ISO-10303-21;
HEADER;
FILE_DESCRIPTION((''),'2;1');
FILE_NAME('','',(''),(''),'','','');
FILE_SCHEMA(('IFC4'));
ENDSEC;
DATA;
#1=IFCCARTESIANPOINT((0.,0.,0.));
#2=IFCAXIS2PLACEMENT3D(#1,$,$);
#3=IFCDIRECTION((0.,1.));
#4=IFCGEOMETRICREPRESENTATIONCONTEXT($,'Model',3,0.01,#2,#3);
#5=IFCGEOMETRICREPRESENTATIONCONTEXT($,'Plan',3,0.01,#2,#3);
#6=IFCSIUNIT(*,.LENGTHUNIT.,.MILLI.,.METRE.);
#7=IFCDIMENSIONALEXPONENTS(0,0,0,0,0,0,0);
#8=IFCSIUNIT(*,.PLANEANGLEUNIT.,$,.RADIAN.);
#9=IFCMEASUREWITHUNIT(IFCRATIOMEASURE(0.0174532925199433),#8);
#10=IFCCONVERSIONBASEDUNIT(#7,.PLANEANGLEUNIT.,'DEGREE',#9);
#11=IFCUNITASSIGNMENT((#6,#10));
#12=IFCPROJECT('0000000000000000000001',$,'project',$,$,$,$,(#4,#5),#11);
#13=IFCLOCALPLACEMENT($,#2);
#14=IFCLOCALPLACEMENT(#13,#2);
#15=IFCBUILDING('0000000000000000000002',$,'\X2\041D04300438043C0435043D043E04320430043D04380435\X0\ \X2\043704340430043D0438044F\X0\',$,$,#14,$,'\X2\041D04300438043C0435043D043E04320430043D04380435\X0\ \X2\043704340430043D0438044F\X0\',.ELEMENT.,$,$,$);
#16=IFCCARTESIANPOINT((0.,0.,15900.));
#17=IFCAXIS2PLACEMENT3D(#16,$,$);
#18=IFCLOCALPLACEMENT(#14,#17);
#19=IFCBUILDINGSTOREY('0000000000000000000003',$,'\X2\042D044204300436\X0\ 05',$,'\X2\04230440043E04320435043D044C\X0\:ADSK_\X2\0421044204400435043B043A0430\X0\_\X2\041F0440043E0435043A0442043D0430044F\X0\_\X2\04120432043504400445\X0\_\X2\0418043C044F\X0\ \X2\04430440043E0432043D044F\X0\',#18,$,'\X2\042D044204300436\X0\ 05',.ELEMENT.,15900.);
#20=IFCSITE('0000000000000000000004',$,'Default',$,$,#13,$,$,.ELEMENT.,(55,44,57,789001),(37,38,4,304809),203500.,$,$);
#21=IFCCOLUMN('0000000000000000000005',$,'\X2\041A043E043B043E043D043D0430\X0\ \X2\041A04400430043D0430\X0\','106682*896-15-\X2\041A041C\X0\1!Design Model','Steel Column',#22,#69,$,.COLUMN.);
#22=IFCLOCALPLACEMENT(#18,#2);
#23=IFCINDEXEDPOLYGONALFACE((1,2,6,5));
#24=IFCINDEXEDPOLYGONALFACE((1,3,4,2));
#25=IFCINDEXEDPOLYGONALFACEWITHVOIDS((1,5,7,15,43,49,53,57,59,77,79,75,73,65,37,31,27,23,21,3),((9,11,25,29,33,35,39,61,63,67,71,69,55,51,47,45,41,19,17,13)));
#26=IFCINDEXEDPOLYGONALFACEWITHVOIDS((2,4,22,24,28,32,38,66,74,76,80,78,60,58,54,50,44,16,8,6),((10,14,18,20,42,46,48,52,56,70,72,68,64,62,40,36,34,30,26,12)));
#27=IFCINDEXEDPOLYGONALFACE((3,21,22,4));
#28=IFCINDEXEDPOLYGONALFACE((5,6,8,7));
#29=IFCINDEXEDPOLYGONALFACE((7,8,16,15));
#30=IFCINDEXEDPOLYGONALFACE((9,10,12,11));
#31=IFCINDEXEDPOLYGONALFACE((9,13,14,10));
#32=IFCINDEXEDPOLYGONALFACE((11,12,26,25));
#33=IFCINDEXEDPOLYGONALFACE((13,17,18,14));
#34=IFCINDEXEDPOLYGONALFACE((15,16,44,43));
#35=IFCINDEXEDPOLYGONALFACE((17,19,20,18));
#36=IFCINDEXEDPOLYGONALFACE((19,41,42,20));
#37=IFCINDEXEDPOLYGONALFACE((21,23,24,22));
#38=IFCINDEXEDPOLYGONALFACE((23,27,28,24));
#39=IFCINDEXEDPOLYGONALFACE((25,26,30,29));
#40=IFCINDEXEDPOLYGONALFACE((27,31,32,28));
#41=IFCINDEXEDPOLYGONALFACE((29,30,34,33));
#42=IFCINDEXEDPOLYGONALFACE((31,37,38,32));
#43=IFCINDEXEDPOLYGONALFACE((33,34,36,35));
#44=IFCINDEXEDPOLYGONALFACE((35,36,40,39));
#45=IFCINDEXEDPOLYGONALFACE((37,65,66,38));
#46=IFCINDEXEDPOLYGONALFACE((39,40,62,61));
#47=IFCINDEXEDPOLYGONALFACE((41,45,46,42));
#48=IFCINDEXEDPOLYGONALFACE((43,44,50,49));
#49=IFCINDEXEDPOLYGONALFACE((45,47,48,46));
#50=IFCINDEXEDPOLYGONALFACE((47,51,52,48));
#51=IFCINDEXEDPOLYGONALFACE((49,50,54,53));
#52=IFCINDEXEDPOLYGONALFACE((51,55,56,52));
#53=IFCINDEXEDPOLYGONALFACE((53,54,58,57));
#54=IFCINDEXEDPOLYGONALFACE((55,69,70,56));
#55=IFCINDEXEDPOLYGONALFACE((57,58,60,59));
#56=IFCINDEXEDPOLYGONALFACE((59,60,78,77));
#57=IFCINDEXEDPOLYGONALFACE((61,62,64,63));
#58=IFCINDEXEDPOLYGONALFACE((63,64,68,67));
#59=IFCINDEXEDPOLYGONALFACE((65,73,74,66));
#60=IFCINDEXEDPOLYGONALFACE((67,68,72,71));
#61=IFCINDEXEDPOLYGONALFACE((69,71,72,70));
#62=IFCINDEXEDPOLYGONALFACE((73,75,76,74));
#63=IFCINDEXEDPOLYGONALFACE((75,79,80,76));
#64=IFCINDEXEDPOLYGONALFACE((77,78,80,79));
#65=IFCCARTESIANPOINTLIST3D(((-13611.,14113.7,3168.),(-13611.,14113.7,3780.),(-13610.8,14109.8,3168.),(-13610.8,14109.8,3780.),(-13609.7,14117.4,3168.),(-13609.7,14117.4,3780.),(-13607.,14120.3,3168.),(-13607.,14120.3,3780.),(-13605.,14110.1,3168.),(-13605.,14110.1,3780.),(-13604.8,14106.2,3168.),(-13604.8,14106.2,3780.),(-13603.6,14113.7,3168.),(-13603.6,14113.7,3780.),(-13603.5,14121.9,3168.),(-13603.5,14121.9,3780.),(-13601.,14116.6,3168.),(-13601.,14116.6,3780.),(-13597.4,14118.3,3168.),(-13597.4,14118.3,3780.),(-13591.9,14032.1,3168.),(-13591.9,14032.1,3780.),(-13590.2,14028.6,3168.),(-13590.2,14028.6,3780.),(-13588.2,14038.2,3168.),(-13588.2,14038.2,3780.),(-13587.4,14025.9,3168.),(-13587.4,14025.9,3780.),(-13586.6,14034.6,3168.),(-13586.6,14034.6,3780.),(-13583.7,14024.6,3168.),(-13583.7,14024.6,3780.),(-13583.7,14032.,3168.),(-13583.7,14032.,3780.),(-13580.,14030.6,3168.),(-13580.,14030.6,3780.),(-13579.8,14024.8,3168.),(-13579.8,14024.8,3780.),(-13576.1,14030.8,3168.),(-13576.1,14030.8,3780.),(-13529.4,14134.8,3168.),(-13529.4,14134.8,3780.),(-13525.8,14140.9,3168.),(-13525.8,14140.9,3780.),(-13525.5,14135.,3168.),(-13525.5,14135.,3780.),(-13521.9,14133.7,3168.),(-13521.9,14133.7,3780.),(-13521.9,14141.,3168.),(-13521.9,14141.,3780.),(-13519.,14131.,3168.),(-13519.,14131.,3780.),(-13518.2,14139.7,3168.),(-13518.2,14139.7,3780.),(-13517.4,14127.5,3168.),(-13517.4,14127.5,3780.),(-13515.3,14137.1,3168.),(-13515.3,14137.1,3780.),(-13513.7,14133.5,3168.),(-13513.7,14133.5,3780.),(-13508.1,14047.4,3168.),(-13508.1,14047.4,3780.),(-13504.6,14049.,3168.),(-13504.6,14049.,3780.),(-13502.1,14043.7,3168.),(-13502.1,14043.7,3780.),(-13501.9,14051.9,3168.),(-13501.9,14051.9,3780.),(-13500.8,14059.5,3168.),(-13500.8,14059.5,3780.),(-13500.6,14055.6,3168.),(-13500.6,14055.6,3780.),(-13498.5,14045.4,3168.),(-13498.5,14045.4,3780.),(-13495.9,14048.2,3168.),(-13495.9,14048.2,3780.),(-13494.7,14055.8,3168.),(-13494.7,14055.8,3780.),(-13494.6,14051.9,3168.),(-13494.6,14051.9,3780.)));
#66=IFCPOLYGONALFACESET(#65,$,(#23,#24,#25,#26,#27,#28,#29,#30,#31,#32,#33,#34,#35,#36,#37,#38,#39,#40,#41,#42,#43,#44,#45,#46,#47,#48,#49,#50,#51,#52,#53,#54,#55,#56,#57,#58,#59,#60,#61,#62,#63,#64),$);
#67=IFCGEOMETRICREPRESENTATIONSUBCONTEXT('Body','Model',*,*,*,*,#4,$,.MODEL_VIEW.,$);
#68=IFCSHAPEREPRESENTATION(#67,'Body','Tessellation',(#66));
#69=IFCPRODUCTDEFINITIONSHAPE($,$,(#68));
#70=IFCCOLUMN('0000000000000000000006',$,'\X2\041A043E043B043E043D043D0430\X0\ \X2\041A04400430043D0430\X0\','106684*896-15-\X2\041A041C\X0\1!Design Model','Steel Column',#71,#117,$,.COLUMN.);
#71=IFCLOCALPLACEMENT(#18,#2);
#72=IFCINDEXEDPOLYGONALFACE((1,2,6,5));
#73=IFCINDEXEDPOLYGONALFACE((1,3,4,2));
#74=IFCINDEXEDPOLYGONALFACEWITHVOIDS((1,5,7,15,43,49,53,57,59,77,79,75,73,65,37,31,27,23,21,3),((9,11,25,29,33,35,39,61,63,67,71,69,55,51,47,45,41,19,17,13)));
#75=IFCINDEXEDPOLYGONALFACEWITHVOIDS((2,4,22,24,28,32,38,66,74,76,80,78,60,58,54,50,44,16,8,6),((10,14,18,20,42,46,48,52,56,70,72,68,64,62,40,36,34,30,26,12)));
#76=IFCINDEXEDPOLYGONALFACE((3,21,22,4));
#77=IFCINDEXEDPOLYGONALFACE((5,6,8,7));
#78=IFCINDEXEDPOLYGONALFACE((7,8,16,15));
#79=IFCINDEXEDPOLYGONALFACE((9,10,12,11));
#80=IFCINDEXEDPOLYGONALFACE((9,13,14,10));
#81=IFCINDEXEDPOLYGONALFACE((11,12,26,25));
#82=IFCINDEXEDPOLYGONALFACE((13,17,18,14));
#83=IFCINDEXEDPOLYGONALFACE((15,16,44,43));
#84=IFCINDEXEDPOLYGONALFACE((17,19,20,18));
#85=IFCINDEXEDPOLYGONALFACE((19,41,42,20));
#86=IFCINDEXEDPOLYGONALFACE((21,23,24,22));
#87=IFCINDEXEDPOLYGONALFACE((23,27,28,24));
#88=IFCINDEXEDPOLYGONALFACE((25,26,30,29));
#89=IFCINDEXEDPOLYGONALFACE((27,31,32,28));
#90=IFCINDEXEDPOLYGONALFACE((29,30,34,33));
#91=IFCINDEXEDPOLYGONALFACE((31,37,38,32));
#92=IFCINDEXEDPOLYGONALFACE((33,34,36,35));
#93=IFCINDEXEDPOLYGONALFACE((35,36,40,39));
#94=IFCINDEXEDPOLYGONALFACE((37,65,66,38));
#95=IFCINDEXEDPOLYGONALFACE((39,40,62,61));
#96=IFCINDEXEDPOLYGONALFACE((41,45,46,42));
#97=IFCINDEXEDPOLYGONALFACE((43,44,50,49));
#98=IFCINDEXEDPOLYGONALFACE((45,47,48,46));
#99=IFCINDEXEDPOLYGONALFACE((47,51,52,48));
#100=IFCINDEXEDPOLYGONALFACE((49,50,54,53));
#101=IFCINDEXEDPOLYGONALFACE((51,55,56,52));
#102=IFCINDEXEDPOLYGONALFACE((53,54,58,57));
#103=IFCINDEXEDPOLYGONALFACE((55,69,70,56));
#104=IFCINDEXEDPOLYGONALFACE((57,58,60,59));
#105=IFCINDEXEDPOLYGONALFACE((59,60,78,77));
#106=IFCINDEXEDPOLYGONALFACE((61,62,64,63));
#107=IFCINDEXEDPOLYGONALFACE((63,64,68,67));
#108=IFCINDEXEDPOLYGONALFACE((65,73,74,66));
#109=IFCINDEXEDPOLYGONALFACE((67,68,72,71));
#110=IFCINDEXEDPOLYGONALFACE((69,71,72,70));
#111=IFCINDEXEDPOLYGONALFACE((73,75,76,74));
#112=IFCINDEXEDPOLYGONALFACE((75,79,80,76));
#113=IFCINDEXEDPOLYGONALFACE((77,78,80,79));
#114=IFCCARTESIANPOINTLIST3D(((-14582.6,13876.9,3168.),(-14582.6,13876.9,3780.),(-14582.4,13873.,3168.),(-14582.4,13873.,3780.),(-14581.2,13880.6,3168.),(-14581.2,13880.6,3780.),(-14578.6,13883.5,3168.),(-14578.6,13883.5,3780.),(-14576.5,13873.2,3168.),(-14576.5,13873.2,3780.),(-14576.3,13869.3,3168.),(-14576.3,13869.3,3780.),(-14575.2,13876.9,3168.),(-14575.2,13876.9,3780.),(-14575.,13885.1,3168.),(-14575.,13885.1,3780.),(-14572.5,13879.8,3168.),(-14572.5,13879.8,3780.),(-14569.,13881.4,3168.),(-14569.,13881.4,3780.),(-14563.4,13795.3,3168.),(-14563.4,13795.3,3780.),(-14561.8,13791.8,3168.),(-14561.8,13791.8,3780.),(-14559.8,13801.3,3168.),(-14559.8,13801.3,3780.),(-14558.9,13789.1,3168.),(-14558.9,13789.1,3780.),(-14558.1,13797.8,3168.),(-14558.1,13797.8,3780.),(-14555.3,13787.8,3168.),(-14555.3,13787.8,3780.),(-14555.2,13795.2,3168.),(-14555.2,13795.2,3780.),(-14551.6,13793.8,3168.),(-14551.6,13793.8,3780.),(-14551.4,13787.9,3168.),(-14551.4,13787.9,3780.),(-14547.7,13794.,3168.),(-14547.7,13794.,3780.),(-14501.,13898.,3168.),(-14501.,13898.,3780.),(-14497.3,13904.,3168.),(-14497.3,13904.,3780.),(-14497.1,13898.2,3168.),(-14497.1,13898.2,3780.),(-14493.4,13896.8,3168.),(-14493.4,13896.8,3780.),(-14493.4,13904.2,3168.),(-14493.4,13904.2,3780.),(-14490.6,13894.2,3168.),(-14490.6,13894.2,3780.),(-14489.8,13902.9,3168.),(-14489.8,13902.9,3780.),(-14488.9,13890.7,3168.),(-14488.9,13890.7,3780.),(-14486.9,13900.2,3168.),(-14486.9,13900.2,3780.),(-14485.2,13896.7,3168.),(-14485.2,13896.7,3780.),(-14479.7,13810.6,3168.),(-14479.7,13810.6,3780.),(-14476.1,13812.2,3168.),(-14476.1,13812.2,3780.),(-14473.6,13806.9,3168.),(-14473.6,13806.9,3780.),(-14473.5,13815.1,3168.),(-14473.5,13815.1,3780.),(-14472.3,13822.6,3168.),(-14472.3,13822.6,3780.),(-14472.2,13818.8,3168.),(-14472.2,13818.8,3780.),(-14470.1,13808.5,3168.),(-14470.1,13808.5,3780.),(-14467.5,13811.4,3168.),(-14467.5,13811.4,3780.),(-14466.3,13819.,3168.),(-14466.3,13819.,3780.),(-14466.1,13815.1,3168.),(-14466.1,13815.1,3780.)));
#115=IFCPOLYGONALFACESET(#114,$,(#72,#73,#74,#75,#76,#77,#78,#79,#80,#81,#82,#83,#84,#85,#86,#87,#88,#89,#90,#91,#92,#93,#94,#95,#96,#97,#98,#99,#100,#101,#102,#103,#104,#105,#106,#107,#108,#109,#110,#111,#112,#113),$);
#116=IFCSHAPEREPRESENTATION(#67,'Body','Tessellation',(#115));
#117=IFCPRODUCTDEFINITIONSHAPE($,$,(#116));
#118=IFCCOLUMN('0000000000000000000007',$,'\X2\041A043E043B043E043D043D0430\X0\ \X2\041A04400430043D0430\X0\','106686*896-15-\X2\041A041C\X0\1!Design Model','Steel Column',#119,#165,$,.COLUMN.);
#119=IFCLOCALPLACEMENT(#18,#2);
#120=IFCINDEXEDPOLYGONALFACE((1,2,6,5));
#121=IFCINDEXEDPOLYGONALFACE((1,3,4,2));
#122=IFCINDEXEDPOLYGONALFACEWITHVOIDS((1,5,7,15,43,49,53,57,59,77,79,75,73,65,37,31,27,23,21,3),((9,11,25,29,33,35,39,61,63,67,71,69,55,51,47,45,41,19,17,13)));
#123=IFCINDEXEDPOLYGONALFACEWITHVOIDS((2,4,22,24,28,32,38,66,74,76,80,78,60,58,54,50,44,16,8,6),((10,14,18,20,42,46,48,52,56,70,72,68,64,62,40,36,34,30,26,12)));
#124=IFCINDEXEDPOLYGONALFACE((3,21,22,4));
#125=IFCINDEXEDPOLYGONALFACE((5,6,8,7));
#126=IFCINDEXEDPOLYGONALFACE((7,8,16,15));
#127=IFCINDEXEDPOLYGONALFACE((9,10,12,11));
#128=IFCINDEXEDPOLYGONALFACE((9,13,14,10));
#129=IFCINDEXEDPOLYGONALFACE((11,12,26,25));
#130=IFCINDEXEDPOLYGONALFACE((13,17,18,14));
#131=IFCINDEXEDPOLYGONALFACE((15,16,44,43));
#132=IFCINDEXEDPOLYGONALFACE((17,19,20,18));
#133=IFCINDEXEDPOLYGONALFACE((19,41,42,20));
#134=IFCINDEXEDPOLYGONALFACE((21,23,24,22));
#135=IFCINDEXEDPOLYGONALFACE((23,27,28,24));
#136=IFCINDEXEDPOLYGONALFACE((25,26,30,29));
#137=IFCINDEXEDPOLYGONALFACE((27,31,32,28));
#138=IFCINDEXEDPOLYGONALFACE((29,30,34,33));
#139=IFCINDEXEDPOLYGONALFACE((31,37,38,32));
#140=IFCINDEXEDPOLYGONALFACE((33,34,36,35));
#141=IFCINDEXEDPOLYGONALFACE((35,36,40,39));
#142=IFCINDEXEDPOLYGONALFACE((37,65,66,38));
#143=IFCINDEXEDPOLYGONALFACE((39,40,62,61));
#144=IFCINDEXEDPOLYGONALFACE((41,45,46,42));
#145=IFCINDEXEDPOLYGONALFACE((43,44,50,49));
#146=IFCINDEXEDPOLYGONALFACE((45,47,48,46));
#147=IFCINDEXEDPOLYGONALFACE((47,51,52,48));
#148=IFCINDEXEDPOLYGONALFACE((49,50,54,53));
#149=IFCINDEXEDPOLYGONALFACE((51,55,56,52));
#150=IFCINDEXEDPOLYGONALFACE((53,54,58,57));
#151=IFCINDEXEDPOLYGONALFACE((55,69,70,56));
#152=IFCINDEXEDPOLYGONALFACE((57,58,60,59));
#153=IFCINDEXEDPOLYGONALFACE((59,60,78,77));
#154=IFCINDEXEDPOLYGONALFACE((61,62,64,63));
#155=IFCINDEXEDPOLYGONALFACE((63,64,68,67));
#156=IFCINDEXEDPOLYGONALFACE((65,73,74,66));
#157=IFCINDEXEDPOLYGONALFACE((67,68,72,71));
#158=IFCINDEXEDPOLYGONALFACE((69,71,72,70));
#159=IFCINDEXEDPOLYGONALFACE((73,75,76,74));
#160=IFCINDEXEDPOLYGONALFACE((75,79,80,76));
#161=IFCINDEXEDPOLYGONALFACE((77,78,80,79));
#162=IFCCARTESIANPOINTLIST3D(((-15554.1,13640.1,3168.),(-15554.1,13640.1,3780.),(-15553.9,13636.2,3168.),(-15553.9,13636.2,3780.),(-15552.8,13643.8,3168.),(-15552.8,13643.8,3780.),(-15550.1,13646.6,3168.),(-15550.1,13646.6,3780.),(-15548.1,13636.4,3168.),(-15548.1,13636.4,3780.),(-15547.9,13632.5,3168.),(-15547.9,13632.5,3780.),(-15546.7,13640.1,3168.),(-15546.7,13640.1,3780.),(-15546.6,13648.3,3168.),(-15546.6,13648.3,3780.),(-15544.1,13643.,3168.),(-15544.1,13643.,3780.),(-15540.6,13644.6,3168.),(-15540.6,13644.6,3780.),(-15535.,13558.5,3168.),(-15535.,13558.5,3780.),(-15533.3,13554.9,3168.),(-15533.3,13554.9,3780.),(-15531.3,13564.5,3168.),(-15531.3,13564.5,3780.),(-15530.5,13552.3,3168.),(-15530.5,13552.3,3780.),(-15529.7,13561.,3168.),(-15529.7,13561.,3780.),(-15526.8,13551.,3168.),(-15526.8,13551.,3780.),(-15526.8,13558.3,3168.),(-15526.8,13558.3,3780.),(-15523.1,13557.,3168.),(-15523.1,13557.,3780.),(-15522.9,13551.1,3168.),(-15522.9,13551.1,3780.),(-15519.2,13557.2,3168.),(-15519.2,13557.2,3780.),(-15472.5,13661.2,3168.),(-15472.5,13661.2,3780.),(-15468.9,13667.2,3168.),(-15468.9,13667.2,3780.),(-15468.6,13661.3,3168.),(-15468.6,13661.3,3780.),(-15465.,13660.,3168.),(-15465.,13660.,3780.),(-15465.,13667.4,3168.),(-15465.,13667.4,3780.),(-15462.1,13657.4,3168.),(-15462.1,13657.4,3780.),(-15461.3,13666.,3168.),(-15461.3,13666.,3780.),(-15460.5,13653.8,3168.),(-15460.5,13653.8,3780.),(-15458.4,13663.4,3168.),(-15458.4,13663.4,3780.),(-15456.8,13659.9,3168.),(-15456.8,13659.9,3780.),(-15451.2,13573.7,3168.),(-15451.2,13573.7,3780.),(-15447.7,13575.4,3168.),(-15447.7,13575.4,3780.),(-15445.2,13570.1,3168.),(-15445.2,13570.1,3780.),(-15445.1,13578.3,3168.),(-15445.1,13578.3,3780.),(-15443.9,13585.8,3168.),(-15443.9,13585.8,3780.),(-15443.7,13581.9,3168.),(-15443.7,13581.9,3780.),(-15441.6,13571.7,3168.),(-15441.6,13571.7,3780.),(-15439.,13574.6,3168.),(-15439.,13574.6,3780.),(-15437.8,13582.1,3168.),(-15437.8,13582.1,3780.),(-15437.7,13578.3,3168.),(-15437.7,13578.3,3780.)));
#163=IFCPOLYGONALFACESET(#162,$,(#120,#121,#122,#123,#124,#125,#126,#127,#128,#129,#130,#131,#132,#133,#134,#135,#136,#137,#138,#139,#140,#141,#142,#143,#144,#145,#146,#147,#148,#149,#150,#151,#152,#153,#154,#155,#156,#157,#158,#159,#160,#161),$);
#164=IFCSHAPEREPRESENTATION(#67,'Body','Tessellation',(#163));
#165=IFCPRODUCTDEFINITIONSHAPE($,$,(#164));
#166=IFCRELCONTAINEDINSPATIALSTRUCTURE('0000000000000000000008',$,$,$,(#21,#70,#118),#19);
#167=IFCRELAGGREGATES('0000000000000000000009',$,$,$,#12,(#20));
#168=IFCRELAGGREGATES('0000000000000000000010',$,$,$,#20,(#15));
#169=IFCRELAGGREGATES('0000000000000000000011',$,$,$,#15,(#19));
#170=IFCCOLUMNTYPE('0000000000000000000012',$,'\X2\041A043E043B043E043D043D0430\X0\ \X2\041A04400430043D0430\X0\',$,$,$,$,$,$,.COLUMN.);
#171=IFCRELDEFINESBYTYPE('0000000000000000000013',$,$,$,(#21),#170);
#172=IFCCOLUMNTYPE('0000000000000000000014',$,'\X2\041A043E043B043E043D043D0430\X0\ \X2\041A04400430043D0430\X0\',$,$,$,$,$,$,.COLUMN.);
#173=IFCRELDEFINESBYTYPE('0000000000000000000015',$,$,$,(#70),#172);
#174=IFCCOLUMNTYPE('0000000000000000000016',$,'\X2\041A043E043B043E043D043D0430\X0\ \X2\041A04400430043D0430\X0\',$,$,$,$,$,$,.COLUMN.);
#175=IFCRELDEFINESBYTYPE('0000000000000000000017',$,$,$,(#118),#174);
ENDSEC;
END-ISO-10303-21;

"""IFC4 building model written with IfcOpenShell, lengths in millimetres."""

from ifc_helpers import new_model, entity, si_unit, converted_unit, direction, frame, origin, place, context, subcontext, project, spatial, indexed_curve, outline, extrude, type_object, element, save


model = new_model("IFC4")

# Units and contexts
model_context = context("Model", 3, precision=0.01, world=origin(), true_north=direction((0.0, 1.0)))
plan_context = context("Plan", 3, precision=0.01, world=origin(), true_north=direction((0.0, 1.0)))
body_context = subcontext(model_context, "Body", "Model", "MODEL_VIEW")
ifc_project = project(units=[si_unit("LENGTHUNIT", "METRE", prefix="MILLI"), converted_unit("PLANEANGLEUNIT", "DEGREE", entity("IfcRatioMeasure", 0.0174532925199433), si_unit("PLANEANGLEUNIT", "RADIAN"), dimensions=[0, 0, 0, 0, 0, 0, 0])], contexts=[model_context, plan_context])

# Site, building, storey
site_placement = place(None, origin())
site = spatial("IfcSite", under=ifc_project, at=site_placement, Name="Default", CompositionType="ELEMENT", RefLatitude=(55, 44, 57, 789001), RefLongitude=(37, 38, 4, 304809), RefElevation=203500.0)
building_placement = place(site_placement, origin())
building = spatial("IfcBuilding", under=site, at=building_placement, Name="Наименование здания", LongName="Наименование здания", CompositionType="ELEMENT")
storey_placement = place(building_placement, frame((0.0, 0.0, 15900.0)))
storey = spatial("IfcBuildingStorey", under=building, at=storey_placement, Name="Этаж 05", ObjectType="Уровень:ADSK_Стрелка_Проектная_Вверх_Имя уровня", LongName="Этаж 05", CompositionType="ELEMENT", Elevation=15900.0)

# Columns
column_type_1 = type_object("IfcColumnType", Name="Колонна Крана", PredefinedType="COLUMN")
column_1_placement = place(storey_placement, origin())
element("IfcColumn", 1, at=column_1_placement, inside=storey, type_object=column_type_1, Name="Колонна Крана", Description="106682*896-15-КМ1!Design Model", ObjectType="Steel Column", PredefinedType="COLUMN", context=body_context, shape_type="SweptSolid", body=[
    extrude(outline(indexed_curve([(29.5, -56.8), (33.4, -56.8), (37.0, -55.3), (39.7, -52.6), (41.2, -49.0), (56.8, 29.5), (56.8, 33.4), (55.3, 37.0), (52.6, 39.7), (49.0, 41.2), (-29.5, 56.8), (-33.4, 56.8), (-37.0, 55.3), (-39.7, 52.6), (-41.2, 49.0), (-56.8, -29.5), (-56.8, -33.4), (-55.3, -37.0), (-52.6, -39.7), (-49.0, -41.2), (29.5, -56.8)], self_intersect=False), holes=[indexed_curve([(-43.1, -37.3), (-46.7, -35.8), (-49.5, -33.1), (-51.0, -29.5), (-51.0, -25.5), (-37.3, 43.1), (-35.8, 46.7), (-33.1, 49.5), (-29.5, 51.0), (-25.5, 51.0), (43.1, 37.3), (46.7, 35.8), (49.5, 33.1), (51.0, 29.5), (51.0, 25.5), (37.3, -43.1), (35.8, -46.7), (33.1, -49.5), (29.5, -51.0), (25.5, -51.0), (-43.1, -37.3)], self_intersect=False)]), frame((-13552.8, 14082.8, 3168.0), z_axis=(0.0, 0.0, 1.0), x_axis=(-0.906681, -0.421816, 0.0)), (0.0, 0.0, 1.0), 612.0),
])
column_type_2 = type_object("IfcColumnType", Name="Колонна Крана", PredefinedType="COLUMN")
column_2_placement = place(storey_placement, origin())
element("IfcColumn", 2, at=column_2_placement, inside=storey, type_object=column_type_2, Name="Колонна Крана", Description="106684*896-15-КМ1!Design Model", ObjectType="Steel Column", PredefinedType="COLUMN", context=body_context, shape_type="SweptSolid", body=[
    extrude(outline(indexed_curve([(29.5, -56.8), (33.4, -56.8), (37.0, -55.3), (39.7, -52.6), (41.2, -49.0), (56.8, 29.5), (56.8, 33.4), (55.3, 37.0), (52.6, 39.7), (49.0, 41.2), (-29.5, 56.8), (-33.4, 56.8), (-37.0, 55.3), (-39.7, 52.6), (-41.2, 49.0), (-56.8, -29.5), (-56.8, -33.4), (-55.3, -37.0), (-52.6, -39.7), (-49.0, -41.2), (29.5, -56.8)], self_intersect=False), holes=[indexed_curve([(-43.1, -37.3), (-46.7, -35.8), (-49.5, -33.1), (-51.0, -29.5), (-51.0, -25.5), (-37.3, 43.1), (-35.8, 46.7), (-33.1, 49.5), (-29.5, 51.0), (-25.5, 51.0), (43.1, 37.3), (46.7, 35.8), (49.5, 33.1), (51.0, 29.5), (51.0, 25.5), (37.3, -43.1), (35.8, -46.7), (33.1, -49.5), (29.5, -51.0), (25.5, -51.0), (-43.1, -37.3)], self_intersect=False)]), frame((-14524.3, 13846.0, 3168.0), z_axis=(0.0, 0.0, 1.0), x_axis=(-0.906681, -0.421816, 0.0)), (0.0, 0.0, 1.0), 612.0),
])
column_type_3 = type_object("IfcColumnType", Name="Колонна Крана", PredefinedType="COLUMN")
column_3_placement = place(storey_placement, origin())
element("IfcColumn", 3, at=column_3_placement, inside=storey, type_object=column_type_3, Name="Колонна Крана", Description="106686*896-15-КМ1!Design Model", ObjectType="Steel Column", PredefinedType="COLUMN", context=body_context, shape_type="SweptSolid", body=[
    extrude(outline(indexed_curve([(29.5, -56.8), (33.4, -56.8), (37.0, -55.3), (39.7, -52.6), (41.2, -49.0), (56.8, 29.5), (56.8, 33.4), (55.3, 37.0), (52.6, 39.7), (49.0, 41.2), (-29.5, 56.8), (-33.4, 56.8), (-37.0, 55.3), (-39.7, 52.6), (-41.2, 49.0), (-56.8, -29.5), (-56.8, -33.4), (-55.3, -37.0), (-52.6, -39.7), (-49.0, -41.2), (29.5, -56.8)], self_intersect=False), holes=[indexed_curve([(-43.1, -37.3), (-46.7, -35.8), (-49.5, -33.1), (-51.0, -29.5), (-51.0, -25.5), (-37.3, 43.1), (-35.8, 46.7), (-33.1, 49.5), (-29.5, 51.0), (-25.5, 51.0), (43.1, 37.3), (46.7, 35.8), (49.5, 33.1), (51.0, 29.5), (51.0, 25.5), (37.3, -43.1), (35.8, -46.7), (33.1, -49.5), (29.5, -51.0), (25.5, -51.0), (-43.1, -37.3)], self_intersect=False)]), frame((-15495.9, 13609.2, 3168.0), z_axis=(0.0, 0.0, 1.0), x_axis=(-0.906681, -0.421816, 0.0)), (0.0, 0.0, 1.0), 612.0),
])

save(model, "model.ifc")
